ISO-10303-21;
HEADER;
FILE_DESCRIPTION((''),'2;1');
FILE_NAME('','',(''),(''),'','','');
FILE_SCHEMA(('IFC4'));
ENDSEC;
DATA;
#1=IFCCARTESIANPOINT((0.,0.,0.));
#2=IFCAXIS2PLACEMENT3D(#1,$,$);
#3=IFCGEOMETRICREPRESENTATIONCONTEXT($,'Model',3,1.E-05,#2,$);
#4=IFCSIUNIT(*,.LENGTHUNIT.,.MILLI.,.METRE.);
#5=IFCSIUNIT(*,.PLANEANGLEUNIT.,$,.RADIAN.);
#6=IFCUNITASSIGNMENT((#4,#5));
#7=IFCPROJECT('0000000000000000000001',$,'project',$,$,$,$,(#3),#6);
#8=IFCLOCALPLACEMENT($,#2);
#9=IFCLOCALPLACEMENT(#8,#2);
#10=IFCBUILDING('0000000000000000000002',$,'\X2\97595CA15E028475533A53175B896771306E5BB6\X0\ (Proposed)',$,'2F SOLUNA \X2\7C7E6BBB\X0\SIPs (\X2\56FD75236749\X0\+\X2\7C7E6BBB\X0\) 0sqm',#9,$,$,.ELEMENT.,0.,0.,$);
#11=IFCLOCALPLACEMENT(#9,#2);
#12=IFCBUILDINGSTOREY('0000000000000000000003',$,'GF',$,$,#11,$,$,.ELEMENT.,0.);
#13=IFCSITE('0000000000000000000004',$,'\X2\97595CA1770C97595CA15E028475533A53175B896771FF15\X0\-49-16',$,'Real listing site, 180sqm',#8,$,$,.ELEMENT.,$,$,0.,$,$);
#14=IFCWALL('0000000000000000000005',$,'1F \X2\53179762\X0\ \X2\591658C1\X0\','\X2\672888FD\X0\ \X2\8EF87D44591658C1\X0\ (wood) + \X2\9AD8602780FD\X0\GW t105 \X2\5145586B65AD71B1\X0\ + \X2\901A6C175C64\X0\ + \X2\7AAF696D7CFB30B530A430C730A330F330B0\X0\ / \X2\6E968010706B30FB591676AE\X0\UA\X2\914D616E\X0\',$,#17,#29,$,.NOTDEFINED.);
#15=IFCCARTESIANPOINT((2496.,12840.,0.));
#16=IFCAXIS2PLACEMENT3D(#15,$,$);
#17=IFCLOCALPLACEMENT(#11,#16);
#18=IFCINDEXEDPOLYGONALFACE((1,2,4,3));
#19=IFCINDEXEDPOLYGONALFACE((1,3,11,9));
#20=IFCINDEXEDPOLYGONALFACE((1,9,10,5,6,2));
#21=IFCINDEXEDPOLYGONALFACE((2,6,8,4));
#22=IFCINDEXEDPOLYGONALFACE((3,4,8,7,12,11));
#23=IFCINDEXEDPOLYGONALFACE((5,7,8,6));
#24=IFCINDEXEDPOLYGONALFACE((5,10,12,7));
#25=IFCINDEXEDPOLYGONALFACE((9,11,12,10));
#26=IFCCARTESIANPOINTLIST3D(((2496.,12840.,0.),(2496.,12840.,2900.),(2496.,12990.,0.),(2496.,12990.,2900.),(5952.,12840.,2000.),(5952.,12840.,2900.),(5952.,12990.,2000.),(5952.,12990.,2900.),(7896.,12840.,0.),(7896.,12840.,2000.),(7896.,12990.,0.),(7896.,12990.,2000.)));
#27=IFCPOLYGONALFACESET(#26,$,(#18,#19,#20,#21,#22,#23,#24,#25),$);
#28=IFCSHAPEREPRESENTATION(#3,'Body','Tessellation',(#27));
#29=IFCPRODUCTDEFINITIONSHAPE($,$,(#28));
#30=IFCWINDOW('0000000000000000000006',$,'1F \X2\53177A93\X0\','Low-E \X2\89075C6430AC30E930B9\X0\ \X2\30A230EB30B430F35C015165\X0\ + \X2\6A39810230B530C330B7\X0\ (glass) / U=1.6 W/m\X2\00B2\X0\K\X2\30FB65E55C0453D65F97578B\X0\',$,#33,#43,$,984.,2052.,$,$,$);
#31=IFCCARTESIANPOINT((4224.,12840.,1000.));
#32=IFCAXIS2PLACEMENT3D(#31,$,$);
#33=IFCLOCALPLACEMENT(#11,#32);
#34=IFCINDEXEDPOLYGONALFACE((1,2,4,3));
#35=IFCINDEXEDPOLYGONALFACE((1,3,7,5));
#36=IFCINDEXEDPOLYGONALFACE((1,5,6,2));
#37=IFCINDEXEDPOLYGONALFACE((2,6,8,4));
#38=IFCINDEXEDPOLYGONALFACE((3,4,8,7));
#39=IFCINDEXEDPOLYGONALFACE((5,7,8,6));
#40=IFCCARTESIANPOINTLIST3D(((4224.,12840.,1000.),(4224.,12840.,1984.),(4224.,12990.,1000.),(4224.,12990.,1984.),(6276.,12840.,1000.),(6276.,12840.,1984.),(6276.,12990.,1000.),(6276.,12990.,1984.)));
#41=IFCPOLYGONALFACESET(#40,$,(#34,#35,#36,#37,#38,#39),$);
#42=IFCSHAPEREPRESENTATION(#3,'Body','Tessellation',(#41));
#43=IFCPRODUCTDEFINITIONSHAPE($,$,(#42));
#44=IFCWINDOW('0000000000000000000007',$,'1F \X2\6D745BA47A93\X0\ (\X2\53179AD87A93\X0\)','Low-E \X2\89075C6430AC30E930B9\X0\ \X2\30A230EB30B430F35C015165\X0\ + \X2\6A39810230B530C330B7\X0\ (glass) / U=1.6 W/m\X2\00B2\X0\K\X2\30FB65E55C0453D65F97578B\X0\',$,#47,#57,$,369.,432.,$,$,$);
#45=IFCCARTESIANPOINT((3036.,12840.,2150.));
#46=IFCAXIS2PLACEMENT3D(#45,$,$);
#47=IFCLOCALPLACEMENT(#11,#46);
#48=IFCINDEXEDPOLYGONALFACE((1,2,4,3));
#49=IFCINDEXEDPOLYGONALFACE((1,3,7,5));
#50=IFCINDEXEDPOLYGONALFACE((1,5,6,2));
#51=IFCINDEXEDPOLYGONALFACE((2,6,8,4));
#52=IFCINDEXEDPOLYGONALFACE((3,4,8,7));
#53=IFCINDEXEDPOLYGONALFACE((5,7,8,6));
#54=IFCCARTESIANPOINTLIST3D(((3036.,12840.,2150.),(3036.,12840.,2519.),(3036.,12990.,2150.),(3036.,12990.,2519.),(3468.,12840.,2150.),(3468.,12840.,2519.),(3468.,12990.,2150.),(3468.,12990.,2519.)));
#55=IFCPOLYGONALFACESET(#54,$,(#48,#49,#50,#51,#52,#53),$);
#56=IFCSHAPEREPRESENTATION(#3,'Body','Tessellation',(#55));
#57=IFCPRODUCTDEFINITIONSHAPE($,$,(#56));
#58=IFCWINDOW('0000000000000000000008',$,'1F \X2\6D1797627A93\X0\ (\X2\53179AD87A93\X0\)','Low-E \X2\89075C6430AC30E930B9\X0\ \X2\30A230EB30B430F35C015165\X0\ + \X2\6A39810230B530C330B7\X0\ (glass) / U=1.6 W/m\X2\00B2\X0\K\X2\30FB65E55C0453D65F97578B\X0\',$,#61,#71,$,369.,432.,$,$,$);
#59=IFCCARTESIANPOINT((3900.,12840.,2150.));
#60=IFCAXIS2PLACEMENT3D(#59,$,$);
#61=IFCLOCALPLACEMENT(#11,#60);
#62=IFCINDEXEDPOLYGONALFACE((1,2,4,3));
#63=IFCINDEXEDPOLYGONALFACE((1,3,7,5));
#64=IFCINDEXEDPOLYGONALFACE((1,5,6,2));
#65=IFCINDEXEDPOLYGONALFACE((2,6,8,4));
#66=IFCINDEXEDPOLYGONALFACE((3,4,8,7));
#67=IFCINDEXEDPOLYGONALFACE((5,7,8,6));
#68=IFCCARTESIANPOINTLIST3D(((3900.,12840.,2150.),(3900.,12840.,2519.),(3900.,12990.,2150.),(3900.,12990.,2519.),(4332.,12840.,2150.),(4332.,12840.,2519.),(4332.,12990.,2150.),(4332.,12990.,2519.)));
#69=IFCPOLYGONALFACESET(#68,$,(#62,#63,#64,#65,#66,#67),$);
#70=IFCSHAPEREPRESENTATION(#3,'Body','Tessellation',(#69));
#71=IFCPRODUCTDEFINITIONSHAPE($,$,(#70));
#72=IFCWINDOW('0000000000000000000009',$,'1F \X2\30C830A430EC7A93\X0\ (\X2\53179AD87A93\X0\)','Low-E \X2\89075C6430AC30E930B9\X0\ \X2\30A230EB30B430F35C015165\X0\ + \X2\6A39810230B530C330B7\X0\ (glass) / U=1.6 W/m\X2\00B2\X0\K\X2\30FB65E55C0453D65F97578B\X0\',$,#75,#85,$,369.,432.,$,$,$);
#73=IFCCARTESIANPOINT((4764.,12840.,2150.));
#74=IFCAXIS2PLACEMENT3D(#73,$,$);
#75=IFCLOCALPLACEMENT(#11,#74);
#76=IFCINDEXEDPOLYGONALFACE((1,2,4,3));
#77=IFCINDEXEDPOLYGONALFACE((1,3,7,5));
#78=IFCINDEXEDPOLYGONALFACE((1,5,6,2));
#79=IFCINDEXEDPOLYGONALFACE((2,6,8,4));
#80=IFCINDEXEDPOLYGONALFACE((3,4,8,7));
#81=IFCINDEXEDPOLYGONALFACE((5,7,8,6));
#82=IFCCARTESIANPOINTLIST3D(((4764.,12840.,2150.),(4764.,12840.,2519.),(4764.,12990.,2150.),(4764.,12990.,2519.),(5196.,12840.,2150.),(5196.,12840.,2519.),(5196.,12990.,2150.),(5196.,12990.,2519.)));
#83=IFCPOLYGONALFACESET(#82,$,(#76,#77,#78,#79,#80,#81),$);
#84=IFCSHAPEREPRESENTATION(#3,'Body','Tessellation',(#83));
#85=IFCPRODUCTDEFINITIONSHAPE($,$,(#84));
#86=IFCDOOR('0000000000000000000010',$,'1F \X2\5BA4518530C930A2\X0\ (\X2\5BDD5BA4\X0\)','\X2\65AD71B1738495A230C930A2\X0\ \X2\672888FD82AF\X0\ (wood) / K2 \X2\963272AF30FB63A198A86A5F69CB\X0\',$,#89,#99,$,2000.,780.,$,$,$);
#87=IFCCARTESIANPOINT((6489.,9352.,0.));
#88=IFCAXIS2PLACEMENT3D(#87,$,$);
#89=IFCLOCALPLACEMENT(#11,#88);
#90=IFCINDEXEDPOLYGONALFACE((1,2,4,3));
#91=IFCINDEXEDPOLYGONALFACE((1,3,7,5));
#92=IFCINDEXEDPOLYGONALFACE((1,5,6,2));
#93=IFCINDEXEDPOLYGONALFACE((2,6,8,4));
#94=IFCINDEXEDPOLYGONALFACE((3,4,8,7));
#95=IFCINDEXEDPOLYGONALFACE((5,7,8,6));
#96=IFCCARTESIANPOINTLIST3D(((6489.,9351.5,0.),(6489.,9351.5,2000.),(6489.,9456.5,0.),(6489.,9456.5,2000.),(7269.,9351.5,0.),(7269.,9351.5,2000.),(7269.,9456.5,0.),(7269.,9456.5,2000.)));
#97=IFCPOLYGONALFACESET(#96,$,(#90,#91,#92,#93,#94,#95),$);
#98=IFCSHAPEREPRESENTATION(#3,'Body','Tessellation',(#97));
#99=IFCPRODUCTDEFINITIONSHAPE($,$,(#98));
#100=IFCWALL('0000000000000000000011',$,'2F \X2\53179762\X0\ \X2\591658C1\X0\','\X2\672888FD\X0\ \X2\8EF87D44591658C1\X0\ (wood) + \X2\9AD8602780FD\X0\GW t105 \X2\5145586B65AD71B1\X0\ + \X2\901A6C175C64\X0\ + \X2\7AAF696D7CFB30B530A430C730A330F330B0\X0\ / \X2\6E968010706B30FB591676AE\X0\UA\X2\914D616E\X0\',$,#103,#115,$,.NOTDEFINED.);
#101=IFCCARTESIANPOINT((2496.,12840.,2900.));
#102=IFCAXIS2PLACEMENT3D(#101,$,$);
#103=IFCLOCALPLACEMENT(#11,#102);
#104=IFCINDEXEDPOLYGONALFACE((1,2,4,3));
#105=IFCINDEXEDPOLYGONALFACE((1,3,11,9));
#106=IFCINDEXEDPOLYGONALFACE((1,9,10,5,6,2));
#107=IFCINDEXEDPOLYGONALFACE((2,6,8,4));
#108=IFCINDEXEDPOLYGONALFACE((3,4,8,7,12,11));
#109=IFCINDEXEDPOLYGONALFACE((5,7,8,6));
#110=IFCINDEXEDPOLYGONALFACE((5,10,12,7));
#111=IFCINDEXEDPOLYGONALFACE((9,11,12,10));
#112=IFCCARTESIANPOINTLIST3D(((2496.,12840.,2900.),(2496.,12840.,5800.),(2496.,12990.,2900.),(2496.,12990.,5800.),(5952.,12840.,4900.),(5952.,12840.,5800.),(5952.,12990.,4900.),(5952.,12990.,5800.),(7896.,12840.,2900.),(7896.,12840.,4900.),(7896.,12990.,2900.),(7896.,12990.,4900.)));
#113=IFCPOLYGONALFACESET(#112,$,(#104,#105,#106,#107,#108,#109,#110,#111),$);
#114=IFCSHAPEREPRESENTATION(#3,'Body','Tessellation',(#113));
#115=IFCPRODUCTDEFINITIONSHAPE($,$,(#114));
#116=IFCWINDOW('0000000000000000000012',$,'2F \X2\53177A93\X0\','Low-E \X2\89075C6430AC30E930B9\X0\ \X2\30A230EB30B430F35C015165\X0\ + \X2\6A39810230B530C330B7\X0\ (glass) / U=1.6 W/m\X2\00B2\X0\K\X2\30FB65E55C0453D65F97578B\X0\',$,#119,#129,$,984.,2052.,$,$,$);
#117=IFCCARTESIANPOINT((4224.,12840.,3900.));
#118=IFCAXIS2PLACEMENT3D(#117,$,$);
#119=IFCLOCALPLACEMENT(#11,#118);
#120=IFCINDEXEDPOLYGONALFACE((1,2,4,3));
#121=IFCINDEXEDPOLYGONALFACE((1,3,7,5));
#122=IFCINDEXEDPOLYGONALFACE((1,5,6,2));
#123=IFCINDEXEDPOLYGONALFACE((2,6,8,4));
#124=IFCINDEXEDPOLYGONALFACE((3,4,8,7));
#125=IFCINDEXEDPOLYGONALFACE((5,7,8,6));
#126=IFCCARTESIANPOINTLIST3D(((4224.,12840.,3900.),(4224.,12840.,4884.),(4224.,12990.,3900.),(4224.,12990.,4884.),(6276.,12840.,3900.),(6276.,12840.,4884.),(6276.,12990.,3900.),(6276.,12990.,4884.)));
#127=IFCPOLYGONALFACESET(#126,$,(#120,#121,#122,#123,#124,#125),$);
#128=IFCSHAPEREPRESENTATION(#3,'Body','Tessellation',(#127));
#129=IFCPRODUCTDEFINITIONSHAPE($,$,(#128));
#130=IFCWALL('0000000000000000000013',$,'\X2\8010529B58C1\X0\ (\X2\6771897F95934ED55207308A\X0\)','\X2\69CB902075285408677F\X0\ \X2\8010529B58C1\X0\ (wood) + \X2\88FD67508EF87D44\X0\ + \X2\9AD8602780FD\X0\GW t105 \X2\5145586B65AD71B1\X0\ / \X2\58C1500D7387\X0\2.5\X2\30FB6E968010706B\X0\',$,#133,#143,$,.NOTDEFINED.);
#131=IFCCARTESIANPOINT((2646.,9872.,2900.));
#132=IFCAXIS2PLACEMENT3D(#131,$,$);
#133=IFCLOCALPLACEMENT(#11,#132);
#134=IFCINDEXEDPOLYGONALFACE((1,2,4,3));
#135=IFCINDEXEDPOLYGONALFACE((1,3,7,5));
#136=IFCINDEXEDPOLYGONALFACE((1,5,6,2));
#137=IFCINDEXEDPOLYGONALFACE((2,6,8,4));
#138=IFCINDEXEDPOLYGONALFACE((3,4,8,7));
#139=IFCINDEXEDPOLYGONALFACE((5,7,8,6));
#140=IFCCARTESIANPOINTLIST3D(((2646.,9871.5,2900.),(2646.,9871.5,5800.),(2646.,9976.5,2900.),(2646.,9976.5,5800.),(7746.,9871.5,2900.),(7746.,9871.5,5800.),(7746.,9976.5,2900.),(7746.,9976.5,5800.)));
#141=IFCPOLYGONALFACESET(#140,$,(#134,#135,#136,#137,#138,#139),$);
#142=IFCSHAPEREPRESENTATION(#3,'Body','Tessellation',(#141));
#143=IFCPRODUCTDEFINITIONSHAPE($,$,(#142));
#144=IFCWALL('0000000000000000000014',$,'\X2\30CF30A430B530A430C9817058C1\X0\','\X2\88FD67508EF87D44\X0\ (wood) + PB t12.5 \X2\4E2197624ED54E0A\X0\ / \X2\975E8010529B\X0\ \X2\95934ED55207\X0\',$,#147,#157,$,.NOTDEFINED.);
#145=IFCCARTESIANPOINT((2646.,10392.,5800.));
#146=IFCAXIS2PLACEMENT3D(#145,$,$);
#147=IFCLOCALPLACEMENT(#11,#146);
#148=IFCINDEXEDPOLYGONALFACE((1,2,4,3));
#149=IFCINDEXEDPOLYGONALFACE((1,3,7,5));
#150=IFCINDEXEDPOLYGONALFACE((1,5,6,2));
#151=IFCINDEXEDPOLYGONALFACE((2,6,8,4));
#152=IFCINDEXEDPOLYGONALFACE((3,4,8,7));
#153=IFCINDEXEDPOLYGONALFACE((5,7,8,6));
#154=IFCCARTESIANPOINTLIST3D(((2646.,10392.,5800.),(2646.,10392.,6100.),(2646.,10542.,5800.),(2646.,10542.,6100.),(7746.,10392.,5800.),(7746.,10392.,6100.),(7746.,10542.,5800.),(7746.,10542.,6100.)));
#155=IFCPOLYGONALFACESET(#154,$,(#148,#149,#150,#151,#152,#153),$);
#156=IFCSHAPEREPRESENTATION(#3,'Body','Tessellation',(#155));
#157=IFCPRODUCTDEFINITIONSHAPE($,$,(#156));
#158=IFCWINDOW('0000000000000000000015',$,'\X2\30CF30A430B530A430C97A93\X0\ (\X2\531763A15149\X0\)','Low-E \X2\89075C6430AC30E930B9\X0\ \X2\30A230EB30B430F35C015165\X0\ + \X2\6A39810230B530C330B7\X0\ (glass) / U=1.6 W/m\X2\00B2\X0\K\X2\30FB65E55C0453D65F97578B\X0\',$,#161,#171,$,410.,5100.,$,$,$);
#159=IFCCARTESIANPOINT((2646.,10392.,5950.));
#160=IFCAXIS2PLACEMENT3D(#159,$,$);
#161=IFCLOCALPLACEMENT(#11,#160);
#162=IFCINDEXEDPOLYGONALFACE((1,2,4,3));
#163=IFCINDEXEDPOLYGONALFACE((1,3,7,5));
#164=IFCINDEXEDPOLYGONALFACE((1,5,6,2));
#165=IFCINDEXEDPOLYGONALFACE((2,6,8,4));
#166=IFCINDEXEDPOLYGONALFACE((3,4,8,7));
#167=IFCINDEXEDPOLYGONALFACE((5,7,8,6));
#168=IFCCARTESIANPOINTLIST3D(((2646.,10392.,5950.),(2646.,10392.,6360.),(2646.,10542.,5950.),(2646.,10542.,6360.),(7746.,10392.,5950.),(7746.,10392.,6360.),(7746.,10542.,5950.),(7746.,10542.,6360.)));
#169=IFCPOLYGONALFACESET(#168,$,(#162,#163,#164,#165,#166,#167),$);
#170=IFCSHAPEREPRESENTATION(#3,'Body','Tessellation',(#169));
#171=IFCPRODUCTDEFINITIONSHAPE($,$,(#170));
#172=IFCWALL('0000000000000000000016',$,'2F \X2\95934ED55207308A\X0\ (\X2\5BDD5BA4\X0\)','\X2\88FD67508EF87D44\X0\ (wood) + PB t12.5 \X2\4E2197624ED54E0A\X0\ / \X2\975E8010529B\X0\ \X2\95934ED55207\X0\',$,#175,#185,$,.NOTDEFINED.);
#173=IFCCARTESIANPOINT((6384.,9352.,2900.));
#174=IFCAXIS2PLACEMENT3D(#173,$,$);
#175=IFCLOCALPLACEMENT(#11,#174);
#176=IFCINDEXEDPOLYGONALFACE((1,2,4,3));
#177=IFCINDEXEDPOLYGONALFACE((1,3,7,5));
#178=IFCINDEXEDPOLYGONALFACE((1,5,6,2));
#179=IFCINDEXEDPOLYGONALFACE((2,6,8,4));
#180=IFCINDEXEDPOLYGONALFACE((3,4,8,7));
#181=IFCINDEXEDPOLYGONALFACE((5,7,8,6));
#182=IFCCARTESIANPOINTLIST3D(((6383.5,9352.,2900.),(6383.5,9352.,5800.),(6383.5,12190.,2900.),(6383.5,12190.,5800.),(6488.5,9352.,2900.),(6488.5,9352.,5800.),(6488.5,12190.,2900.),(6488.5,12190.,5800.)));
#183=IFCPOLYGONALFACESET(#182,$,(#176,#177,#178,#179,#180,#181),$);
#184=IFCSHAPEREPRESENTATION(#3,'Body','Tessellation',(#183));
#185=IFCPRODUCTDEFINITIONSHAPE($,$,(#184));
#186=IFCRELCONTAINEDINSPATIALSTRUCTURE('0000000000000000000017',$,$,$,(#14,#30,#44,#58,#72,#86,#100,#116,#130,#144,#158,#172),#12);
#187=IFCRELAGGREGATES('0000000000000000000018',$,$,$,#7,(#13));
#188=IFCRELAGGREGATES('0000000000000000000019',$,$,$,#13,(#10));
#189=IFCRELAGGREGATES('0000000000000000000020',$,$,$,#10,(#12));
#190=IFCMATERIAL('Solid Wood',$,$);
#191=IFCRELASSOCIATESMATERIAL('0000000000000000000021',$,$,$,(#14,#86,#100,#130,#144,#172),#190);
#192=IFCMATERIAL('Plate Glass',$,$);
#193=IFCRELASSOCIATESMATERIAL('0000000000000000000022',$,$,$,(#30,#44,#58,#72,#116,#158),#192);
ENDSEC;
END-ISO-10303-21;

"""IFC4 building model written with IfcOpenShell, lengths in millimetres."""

from ifc_helpers import new_model, si_unit, frame, frame_2d, origin, place, context, project, spatial, rectangle, extrude, material, element, fill, save


model = new_model("IFC4")

# Units and contexts
model_context = context("Model", 3, precision=1e-05, world=origin())
ifc_project = project(units=[si_unit("LENGTHUNIT", "METRE", prefix="MILLI"), si_unit("PLANEANGLEUNIT", "RADIAN")], contexts=[model_context])

# Site, building, storey
site_placement = place(None, origin())
site = spatial("IfcSite", under=ifc_project, at=site_placement, Name="静岡県静岡市葵区北安東５-49-16", ObjectType="Real listing site, 180sqm", CompositionType="ELEMENT", RefElevation=0.0)
building_placement = place(site_placement, origin())
building = spatial("IfcBuilding", under=site, at=building_placement, Name="静岡市葵区北安東の家 (Proposed)", ObjectType="2F SOLUNA 籾殻SIPs (国産杉+籾殻) 0sqm", CompositionType="ELEMENT", ElevationOfRefHeight=0.0, ElevationOfTerrain=0.0)
storey_placement = place(building_placement, origin())
storey = spatial("IfcBuildingStorey", under=building, at=storey_placement, Name="GF", CompositionType="ELEMENT", Elevation=0.0)

# Wall, openings, windows
ifc_material_1 = material(Name="Solid Wood")
wall_1_placement = place(storey_placement, frame((2496.0, 12840.0, 0.0)))
wall_1 = element("IfcWall", 1, at=wall_1_placement, inside=storey, material=ifc_material_1, Name="1F 北面 外壁", Description="木製 軸組外壁 (wood) + 高性能GW t105 充填断熱 + 通気層 + 窯業系サイディング / 準耐火・外皮UA配慮", PredefinedType="NOTDEFINED", context=model_context, shape_type="SweptSolid", body=[
    extrude(rectangle(XDim=5400.0, YDim=150.0, at=frame_2d((2700.0, 75.0))), frame((2496.0, 12840.0, 0.0)), (0.0, 0.0, 1.0), 2900.0),
])
opening_1_placement = place(storey_placement, frame((4224.0, 12840.0, 1000.0)))
opening_1 = element("IfcOpeningElement", 2, at=opening_1_placement, cuts=wall_1, PredefinedType="NOTDEFINED", context=model_context, shape_type="SweptSolid", body=[
    extrude(rectangle(XDim=2052.0, YDim=150.0, at=frame_2d((1026.0, 75.0))), frame((4224.0, 12840.0, 1000.0)), (0.0, 0.0, 1.0), 984.0),
])
opening_2_placement = place(storey_placement, frame((3036.0, 12840.0, 2150.0)))
opening_2 = element("IfcOpeningElement", 3, at=opening_2_placement, cuts=wall_1, PredefinedType="NOTDEFINED", context=model_context, shape_type="SweptSolid", body=[
    extrude(rectangle(XDim=432.0, YDim=150.0, at=frame_2d((216.0, 75.0))), frame((3036.0, 12840.0, 2150.0)), (0.0, 0.0, 1.0), 369.0),
])
opening_3_placement = place(storey_placement, frame((3900.0, 12840.0, 2150.0)))
opening_3 = element("IfcOpeningElement", 4, at=opening_3_placement, cuts=wall_1, PredefinedType="NOTDEFINED", context=model_context, shape_type="SweptSolid", body=[
    extrude(rectangle(XDim=432.0, YDim=150.0, at=frame_2d((216.0, 75.0))), frame((3900.0, 12840.0, 2150.0)), (0.0, 0.0, 1.0), 369.0),
])
opening_4_placement = place(storey_placement, frame((4764.0, 12840.0, 2150.0)))
opening_4 = element("IfcOpeningElement", 5, at=opening_4_placement, cuts=wall_1, PredefinedType="NOTDEFINED", context=model_context, shape_type="SweptSolid", body=[
    extrude(rectangle(XDim=432.0, YDim=150.0, at=frame_2d((216.0, 75.0))), frame((4764.0, 12840.0, 2150.0)), (0.0, 0.0, 1.0), 369.0),
])
ifc_material_2 = material(Name="Plate Glass")
window_1_placement = place(storey_placement, frame((4224.0, 12840.0, 1000.0)))
window_1 = element("IfcWindow", 6, at=window_1_placement, inside=storey, material=ifc_material_2, Name="1F 北窓", Description="Low-E 複層ガラス アルゴン封入 + 樹脂サッシ (glass) / U=1.6 W/m²K・日射取得型", OverallHeight=984.0, OverallWidth=2052.0, context=model_context, shape_type="SweptSolid", body=[
    extrude(rectangle(XDim=2052.0, YDim=150.0, at=frame_2d((1026.0, 75.0))), frame((4224.0, 12840.0, 1000.0)), (0.0, 0.0, 1.0), 984.0),
])
fill(opening_1, window_1)
window_2_placement = place(storey_placement, frame((3036.0, 12840.0, 2150.0)))
window_2 = element("IfcWindow", 7, at=window_2_placement, inside=storey, material=ifc_material_2, Name="1F 浴室窓 (北高窓)", Description="Low-E 複層ガラス アルゴン封入 + 樹脂サッシ (glass) / U=1.6 W/m²K・日射取得型", OverallHeight=369.0, OverallWidth=432.0, context=model_context, shape_type="SweptSolid", body=[
    extrude(rectangle(XDim=432.0, YDim=150.0, at=frame_2d((216.0, 75.0))), frame((3036.0, 12840.0, 2150.0)), (0.0, 0.0, 1.0), 369.0),
])
fill(opening_2, window_2)
window_3_placement = place(storey_placement, frame((3900.0, 12840.0, 2150.0)))
window_3 = element("IfcWindow", 8, at=window_3_placement, inside=storey, material=ifc_material_2, Name="1F 洗面窓 (北高窓)", Description="Low-E 複層ガラス アルゴン封入 + 樹脂サッシ (glass) / U=1.6 W/m²K・日射取得型", OverallHeight=369.0, OverallWidth=432.0, context=model_context, shape_type="SweptSolid", body=[
    extrude(rectangle(XDim=432.0, YDim=150.0, at=frame_2d((216.0, 75.0))), frame((3900.0, 12840.0, 2150.0)), (0.0, 0.0, 1.0), 369.0),
])
fill(opening_3, window_3)
window_4_placement = place(storey_placement, frame((4764.0, 12840.0, 2150.0)))
window_4 = element("IfcWindow", 9, at=window_4_placement, inside=storey, material=ifc_material_2, Name="1F トイレ窓 (北高窓)", Description="Low-E 複層ガラス アルゴン封入 + 樹脂サッシ (glass) / U=1.6 W/m²K・日射取得型", OverallHeight=369.0, OverallWidth=432.0, context=model_context, shape_type="SweptSolid", body=[
    extrude(rectangle(XDim=432.0, YDim=150.0, at=frame_2d((216.0, 75.0))), frame((4764.0, 12840.0, 2150.0)), (0.0, 0.0, 1.0), 369.0),
])
fill(opening_4, window_4)

# Door
door_1_placement = place(storey_placement, frame((6489.0, 9352.0, 0.0)))
element("IfcDoor", 10, at=door_1_placement, inside=storey, material=ifc_material_1, Name="1F 室内ドア (寝室)", Description="断熱玄関ドア 木製芯 (wood) / K2 防犯・採風機構", OverallHeight=2000.0, OverallWidth=780.0, context=model_context, shape_type="SweptSolid", body=[
    extrude(rectangle(XDim=780.0, YDim=105.0, at=frame_2d((390.0, 52.0))), frame((6489.0, 9352.0, 0.0)), (0.0, 0.0, 1.0), 2000.0),
])

# Wall, opening, window
wall_2_placement = place(storey_placement, frame((2496.0, 12840.0, 2900.0)))
wall_2 = element("IfcWall", 11, at=wall_2_placement, inside=storey, material=ifc_material_1, Name="2F 北面 外壁", Description="木製 軸組外壁 (wood) + 高性能GW t105 充填断熱 + 通気層 + 窯業系サイディング / 準耐火・外皮UA配慮", PredefinedType="NOTDEFINED", context=model_context, shape_type="SweptSolid", body=[
    extrude(rectangle(XDim=5400.0, YDim=150.0, at=frame_2d((2700.0, 75.0))), frame((2496.0, 12840.0, 2900.0)), (0.0, 0.0, 1.0), 2900.0),
])
opening_5_placement = place(storey_placement, frame((4224.0, 12840.0, 3900.0)))
opening_5 = element("IfcOpeningElement", 12, at=opening_5_placement, cuts=wall_2, PredefinedType="NOTDEFINED", context=model_context, shape_type="SweptSolid", body=[
    extrude(rectangle(XDim=2052.0, YDim=150.0, at=frame_2d((1026.0, 75.0))), frame((4224.0, 12840.0, 3900.0)), (0.0, 0.0, 1.0), 984.0),
])
window_5_placement = place(storey_placement, frame((4224.0, 12840.0, 3900.0)))
window_5 = element("IfcWindow", 13, at=window_5_placement, inside=storey, material=ifc_material_2, Name="2F 北窓", Description="Low-E 複層ガラス アルゴン封入 + 樹脂サッシ (glass) / U=1.6 W/m²K・日射取得型", OverallHeight=984.0, OverallWidth=2052.0, context=model_context, shape_type="SweptSolid", body=[
    extrude(rectangle(XDim=2052.0, YDim=150.0, at=frame_2d((1026.0, 75.0))), frame((4224.0, 12840.0, 3900.0)), (0.0, 0.0, 1.0), 984.0),
])
fill(opening_5, window_5)

# Wall
wall_3_placement = place(storey_placement, frame((2646.0, 9872.0, 2900.0)))
element("IfcWall", 14, at=wall_3_placement, inside=storey, material=ifc_material_1, Name="耐力壁 (東西間仕切り)", Description="構造用合板 耐力壁 (wood) + 製材軸組 + 高性能GW t105 充填断熱 / 壁倍率2.5・準耐火", PredefinedType="NOTDEFINED", context=model_context, shape_type="SweptSolid", body=[
    extrude(rectangle(XDim=5100.0, YDim=105.0, at=frame_2d((2550.0, 52.0))), frame((2646.0, 9872.0, 2900.0)), (0.0, 0.0, 1.0), 2900.0),
])

# Wall, opening, window
wall_4_placement = place(storey_placement, frame((2646.0, 10392.0, 5800.0)))
wall_4 = element("IfcWall", 15, at=wall_4_placement, inside=storey, material=ifc_material_1, Name="ハイサイド腰壁", Description="製材軸組 (wood) + PB t12.5 両面仕上 / 非耐力 間仕切", PredefinedType="NOTDEFINED", context=model_context, shape_type="SweptSolid", body=[
    extrude(rectangle(XDim=5100.0, YDim=150.0, at=frame_2d((2550.0, 75.0))), frame((2646.0, 10392.0, 5800.0)), (0.0, 0.0, 1.0), 700.0),
])
opening_6_placement = place(storey_placement, frame((2646.0, 10392.0, 5950.0)))
opening_6 = element("IfcOpeningElement", 16, at=opening_6_placement, cuts=wall_4, PredefinedType="NOTDEFINED", context=model_context, shape_type="SweptSolid", body=[
    extrude(rectangle(XDim=5100.0, YDim=150.0, at=frame_2d((2550.0, 75.0))), frame((2646.0, 10392.0, 5950.0)), (0.0, 0.0, 1.0), 410.0),
])
window_6_placement = place(storey_placement, frame((2646.0, 10392.0, 5950.0)))
window_6 = element("IfcWindow", 17, at=window_6_placement, inside=storey, material=ifc_material_2, Name="ハイサイド窓 (北採光)", Description="Low-E 複層ガラス アルゴン封入 + 樹脂サッシ (glass) / U=1.6 W/m²K・日射取得型", OverallHeight=410.0, OverallWidth=5100.0, context=model_context, shape_type="SweptSolid", body=[
    extrude(rectangle(XDim=5100.0, YDim=150.0, at=frame_2d((2550.0, 75.0))), frame((2646.0, 10392.0, 5950.0)), (0.0, 0.0, 1.0), 410.0),
])
fill(opening_6, window_6)

# Wall
wall_5_placement = place(storey_placement, frame((6384.0, 9352.0, 2900.0)))
element("IfcWall", 18, at=wall_5_placement, inside=storey, material=ifc_material_1, Name="2F 間仕切り (寝室)", Description="製材軸組 (wood) + PB t12.5 両面仕上 / 非耐力 間仕切", PredefinedType="NOTDEFINED", context=model_context, shape_type="SweptSolid", body=[
    extrude(rectangle(XDim=105.0, YDim=2838.0, at=frame_2d((52.0, 1419.0))), frame((6384.0, 9352.0, 2900.0)), (0.0, 0.0, 1.0), 2900.0),
])

save(model, "model.ifc")
